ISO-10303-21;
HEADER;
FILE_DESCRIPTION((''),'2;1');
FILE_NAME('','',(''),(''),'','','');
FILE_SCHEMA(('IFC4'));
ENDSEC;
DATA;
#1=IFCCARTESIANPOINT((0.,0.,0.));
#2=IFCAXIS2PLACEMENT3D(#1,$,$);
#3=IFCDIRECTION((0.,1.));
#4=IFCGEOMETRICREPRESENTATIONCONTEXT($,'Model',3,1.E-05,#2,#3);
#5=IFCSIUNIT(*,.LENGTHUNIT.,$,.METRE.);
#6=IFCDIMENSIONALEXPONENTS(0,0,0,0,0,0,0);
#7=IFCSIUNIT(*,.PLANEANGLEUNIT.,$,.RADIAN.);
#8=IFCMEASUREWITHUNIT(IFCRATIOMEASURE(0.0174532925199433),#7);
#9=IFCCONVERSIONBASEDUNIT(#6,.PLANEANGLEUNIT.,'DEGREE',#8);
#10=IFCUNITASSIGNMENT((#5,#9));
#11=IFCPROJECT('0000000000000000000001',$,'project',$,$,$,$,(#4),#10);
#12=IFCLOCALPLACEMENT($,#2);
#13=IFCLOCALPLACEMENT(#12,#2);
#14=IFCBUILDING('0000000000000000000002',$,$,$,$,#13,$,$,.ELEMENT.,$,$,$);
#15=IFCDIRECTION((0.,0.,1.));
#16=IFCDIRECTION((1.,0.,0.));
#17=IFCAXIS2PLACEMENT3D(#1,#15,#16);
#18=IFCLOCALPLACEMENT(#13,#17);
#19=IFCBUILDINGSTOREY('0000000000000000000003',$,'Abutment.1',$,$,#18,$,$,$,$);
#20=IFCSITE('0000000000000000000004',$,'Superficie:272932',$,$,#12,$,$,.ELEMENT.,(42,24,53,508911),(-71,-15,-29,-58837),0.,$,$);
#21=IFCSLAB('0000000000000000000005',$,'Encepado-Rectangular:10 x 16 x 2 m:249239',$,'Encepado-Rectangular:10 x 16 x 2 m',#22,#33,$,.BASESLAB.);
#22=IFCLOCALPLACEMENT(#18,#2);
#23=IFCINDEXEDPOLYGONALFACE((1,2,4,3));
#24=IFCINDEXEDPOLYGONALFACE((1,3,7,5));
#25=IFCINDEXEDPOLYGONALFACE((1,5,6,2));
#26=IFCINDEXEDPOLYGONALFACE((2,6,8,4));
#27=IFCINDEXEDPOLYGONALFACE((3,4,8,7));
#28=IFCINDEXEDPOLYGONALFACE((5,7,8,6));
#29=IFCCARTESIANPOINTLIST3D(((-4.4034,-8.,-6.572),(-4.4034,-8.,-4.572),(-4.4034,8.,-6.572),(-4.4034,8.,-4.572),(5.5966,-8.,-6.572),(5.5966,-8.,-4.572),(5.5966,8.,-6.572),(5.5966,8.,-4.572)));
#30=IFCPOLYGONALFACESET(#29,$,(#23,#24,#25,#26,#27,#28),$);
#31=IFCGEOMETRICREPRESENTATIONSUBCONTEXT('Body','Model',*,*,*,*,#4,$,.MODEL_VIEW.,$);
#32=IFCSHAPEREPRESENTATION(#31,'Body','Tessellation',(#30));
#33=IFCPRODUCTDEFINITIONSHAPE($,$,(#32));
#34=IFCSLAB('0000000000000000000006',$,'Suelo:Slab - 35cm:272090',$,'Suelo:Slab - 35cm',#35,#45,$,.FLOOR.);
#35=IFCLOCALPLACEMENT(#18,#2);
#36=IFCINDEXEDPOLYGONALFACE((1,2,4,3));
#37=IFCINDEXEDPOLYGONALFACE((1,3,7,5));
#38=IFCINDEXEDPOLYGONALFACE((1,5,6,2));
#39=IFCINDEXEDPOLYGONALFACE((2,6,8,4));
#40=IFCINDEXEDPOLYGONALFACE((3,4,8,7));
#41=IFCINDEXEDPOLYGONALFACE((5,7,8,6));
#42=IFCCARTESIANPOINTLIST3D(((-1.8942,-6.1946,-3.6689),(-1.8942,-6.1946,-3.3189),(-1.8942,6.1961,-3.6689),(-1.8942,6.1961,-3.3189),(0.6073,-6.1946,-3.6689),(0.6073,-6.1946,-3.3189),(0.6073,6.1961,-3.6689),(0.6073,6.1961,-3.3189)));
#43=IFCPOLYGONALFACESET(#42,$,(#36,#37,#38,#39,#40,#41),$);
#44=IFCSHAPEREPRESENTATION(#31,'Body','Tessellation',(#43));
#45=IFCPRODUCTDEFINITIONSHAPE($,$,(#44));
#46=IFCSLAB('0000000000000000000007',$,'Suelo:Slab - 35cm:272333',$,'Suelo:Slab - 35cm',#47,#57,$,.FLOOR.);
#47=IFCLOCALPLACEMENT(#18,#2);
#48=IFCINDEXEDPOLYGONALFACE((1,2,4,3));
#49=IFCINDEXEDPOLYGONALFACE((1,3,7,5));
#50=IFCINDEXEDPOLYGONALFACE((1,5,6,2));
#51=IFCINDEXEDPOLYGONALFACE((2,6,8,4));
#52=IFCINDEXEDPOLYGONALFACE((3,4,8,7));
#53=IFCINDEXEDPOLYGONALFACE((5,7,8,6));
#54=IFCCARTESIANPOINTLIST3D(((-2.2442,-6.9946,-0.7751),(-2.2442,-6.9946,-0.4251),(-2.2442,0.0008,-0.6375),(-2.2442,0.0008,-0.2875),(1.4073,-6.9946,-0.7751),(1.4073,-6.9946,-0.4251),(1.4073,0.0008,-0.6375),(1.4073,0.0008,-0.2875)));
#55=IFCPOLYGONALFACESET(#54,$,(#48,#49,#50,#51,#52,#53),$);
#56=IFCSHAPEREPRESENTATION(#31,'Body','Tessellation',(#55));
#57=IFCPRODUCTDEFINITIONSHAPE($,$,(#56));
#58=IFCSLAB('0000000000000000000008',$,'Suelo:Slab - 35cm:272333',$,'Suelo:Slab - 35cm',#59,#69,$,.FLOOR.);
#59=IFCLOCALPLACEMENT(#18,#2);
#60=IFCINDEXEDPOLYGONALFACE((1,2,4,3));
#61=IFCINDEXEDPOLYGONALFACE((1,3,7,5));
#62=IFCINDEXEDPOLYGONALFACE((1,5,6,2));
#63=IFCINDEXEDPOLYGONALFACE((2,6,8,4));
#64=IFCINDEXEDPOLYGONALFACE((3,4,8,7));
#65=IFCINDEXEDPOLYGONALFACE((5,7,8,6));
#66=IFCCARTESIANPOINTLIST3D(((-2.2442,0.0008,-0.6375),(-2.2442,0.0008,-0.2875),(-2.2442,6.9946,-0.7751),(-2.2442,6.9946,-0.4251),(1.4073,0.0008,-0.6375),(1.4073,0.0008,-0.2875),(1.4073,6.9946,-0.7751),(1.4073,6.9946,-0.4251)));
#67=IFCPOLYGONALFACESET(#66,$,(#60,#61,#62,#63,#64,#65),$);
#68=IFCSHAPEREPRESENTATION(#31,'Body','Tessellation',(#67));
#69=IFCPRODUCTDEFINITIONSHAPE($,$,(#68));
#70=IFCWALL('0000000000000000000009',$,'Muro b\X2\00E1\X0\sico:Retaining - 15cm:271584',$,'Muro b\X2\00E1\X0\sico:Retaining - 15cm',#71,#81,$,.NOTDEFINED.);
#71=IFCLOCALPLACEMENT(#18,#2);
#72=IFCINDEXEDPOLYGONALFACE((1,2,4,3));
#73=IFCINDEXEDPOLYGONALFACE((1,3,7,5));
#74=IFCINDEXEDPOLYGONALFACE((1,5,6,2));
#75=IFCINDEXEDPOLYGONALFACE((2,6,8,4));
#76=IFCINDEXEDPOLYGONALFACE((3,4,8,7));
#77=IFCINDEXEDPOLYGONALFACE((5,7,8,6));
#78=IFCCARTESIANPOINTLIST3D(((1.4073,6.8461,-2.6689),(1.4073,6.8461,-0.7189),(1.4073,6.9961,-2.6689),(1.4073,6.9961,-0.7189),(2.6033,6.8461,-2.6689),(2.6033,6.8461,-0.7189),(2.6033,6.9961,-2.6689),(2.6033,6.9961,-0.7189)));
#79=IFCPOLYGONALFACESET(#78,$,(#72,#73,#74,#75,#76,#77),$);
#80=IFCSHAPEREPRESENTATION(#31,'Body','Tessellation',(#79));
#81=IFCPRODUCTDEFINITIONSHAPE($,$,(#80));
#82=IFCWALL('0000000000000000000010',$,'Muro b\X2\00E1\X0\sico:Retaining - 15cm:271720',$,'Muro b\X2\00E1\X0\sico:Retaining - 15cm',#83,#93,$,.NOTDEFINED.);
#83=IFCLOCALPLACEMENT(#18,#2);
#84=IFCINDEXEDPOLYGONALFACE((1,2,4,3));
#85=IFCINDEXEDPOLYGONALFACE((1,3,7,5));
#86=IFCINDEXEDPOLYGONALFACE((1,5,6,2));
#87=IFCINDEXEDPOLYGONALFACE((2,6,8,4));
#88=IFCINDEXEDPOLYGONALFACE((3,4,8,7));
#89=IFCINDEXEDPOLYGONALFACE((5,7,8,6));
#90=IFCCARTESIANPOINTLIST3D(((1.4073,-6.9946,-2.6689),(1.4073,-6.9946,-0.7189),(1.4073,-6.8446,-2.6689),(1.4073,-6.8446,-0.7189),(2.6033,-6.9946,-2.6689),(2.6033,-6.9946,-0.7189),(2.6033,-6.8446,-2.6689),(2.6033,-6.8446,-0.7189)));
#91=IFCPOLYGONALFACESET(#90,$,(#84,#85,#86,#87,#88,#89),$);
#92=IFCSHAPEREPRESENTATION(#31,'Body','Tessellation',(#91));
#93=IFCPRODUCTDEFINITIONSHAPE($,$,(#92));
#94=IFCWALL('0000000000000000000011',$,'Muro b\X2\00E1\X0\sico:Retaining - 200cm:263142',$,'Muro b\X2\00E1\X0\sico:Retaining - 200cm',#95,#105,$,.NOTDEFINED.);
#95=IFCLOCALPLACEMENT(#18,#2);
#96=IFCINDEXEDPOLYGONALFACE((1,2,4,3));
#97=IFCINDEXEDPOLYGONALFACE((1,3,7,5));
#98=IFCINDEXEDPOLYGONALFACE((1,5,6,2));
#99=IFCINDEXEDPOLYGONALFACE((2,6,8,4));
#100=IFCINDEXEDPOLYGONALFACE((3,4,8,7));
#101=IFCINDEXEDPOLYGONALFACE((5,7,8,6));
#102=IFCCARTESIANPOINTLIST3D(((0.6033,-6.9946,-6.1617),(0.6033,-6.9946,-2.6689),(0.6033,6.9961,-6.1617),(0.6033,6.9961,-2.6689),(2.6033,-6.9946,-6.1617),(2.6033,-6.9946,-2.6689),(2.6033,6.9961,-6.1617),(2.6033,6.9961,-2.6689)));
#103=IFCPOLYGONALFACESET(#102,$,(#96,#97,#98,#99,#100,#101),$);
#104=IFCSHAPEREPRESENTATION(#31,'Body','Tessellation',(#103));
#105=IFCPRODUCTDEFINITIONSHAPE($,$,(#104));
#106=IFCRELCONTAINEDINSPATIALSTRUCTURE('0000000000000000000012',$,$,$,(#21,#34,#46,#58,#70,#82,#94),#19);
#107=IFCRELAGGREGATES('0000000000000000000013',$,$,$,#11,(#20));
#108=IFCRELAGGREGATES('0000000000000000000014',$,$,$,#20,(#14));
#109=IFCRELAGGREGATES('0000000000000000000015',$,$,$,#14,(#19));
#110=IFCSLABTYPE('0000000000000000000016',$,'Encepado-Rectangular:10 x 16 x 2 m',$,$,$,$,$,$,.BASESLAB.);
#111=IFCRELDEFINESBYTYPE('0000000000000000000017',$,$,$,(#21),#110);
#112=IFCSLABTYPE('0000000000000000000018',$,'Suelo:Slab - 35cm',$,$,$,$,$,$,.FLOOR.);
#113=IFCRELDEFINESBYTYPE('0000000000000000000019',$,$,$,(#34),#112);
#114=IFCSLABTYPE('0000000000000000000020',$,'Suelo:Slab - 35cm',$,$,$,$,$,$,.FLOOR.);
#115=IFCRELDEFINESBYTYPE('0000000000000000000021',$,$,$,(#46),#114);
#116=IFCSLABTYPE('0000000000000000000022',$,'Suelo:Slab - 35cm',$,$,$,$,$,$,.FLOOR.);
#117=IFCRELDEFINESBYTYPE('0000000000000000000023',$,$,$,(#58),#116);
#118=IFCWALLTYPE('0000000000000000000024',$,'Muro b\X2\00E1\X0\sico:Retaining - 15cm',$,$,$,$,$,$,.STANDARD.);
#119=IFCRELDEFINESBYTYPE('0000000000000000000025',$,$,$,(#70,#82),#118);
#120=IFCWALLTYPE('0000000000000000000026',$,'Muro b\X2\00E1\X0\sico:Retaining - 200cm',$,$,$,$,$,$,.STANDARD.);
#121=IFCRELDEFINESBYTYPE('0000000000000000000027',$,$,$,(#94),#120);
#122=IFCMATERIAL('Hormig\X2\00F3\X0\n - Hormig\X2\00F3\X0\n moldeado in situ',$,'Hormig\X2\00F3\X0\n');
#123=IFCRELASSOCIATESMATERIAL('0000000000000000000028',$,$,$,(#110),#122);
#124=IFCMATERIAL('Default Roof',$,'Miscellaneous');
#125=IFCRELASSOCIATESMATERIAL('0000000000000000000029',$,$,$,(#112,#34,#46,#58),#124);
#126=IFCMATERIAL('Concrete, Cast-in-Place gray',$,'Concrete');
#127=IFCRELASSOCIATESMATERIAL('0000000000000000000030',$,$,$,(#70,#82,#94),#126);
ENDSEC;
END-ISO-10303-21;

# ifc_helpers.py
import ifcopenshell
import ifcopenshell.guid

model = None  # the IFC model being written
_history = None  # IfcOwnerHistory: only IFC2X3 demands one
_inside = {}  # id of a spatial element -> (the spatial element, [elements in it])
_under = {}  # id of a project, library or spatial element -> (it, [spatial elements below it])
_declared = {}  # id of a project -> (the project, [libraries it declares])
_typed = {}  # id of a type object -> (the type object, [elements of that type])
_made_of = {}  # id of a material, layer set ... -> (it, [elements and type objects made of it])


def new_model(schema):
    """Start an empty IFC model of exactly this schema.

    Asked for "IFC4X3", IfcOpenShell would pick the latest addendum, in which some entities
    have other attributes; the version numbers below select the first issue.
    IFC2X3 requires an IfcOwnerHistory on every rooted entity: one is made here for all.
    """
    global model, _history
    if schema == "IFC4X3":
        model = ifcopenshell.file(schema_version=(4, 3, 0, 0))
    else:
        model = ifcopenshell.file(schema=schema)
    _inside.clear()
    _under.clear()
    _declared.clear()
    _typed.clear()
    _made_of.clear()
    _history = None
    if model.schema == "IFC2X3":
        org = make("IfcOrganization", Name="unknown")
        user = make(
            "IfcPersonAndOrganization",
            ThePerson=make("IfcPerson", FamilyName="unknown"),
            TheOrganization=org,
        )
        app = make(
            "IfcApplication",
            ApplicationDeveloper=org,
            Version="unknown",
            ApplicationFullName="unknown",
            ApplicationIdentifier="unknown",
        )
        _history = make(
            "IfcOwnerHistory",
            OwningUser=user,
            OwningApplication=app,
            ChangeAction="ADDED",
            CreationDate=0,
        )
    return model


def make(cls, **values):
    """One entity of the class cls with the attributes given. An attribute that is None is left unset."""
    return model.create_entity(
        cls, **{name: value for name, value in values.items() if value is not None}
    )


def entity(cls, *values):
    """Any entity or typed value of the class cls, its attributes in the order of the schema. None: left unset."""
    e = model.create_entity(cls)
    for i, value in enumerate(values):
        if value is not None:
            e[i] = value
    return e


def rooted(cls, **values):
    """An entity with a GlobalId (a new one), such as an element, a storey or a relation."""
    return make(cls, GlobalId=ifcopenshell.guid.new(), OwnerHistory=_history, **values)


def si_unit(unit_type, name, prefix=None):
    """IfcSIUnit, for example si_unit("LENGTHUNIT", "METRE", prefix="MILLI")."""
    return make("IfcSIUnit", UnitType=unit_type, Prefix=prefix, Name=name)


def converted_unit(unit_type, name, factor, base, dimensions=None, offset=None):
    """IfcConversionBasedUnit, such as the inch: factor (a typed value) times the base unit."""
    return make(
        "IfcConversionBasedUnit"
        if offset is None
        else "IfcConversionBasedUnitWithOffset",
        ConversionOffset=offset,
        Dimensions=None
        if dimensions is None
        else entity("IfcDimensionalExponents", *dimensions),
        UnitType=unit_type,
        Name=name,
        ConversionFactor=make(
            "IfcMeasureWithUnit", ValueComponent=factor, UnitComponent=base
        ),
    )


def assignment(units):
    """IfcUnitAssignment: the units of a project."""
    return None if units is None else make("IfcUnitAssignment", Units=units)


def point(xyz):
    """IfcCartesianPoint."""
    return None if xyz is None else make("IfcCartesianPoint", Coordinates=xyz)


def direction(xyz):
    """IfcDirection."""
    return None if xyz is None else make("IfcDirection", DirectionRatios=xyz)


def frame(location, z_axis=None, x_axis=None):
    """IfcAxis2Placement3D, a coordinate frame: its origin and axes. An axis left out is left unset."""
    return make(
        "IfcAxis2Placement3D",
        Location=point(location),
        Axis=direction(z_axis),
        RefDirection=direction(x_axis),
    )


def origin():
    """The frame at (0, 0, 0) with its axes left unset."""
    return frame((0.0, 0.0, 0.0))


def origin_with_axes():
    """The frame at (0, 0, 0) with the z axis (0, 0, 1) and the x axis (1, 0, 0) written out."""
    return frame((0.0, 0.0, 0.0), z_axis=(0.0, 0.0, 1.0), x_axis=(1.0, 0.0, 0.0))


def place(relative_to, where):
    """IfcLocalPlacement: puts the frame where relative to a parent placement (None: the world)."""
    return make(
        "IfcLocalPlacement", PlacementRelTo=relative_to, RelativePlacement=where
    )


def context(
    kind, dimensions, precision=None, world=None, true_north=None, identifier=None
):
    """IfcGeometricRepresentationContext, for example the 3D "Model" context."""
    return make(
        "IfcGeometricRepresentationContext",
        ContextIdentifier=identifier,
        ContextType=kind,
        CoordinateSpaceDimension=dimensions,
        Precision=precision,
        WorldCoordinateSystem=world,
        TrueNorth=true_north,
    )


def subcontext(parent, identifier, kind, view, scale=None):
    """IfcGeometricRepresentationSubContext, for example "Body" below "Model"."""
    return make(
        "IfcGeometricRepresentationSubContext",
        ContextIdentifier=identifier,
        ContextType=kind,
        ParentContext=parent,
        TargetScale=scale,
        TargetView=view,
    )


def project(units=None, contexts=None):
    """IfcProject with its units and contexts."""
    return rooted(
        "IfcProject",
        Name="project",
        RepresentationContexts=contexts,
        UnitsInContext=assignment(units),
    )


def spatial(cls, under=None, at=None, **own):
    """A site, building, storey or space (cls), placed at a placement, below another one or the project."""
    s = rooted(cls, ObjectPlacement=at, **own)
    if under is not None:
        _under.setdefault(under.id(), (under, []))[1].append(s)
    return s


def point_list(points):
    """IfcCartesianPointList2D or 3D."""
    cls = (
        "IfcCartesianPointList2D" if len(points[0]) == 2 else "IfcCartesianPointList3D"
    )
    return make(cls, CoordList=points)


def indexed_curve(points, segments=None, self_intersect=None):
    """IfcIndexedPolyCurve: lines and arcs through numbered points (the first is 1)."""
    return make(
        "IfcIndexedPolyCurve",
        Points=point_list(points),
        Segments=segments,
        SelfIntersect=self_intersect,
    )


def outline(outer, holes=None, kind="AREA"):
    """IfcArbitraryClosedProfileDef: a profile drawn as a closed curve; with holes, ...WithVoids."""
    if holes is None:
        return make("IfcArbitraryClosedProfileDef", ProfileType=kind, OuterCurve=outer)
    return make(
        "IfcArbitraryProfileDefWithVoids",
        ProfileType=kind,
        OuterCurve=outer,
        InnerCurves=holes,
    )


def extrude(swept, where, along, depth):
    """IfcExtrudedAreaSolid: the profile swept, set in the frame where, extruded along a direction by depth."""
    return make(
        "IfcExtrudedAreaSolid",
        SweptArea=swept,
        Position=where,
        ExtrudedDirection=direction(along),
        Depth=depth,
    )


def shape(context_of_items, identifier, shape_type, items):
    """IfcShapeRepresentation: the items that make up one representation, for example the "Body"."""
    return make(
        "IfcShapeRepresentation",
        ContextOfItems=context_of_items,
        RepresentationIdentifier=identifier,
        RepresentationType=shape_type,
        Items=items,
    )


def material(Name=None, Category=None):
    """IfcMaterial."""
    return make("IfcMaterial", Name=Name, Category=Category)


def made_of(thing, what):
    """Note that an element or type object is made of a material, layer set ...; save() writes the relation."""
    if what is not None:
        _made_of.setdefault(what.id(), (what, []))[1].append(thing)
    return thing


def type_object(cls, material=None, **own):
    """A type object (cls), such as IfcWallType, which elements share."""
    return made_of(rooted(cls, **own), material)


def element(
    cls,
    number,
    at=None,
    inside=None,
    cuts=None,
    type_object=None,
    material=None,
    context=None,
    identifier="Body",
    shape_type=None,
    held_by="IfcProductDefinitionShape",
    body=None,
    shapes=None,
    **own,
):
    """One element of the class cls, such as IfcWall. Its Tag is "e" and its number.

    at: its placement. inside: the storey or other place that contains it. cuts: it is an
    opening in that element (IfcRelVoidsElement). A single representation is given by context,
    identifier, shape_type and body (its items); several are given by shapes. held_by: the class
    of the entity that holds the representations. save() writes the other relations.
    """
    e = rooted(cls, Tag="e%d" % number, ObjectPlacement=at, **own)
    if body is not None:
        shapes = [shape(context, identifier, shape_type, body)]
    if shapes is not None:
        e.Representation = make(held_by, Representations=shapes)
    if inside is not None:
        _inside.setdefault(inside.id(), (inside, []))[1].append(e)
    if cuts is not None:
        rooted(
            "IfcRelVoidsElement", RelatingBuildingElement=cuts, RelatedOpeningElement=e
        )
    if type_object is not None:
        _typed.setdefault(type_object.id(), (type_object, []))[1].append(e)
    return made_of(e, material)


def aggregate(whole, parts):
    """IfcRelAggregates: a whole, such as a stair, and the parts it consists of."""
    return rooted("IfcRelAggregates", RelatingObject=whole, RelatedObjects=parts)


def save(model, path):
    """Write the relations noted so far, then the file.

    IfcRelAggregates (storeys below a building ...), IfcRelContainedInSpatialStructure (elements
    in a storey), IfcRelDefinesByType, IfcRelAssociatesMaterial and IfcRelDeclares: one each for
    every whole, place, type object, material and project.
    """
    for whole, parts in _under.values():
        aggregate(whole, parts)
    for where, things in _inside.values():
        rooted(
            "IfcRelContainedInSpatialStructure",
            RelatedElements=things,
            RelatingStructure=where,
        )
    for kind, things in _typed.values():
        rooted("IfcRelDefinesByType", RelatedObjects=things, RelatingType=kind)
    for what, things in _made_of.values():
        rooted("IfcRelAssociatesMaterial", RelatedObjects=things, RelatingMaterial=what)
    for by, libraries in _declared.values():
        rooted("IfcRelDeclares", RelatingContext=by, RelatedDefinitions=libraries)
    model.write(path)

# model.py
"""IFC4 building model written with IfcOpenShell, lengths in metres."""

from ifc_helpers import new_model, entity, si_unit, converted_unit, direction, frame, origin, origin_with_axes, place, context, subcontext, project, spatial, indexed_curve, outline, extrude, material, type_object, element, save


model = new_model("IFC4")

# Units and contexts
model_context = context("Model", 3, precision=1e-05, world=origin(), true_north=direction((0.0, 1.0)))
body_context = subcontext(model_context, "Body", "Model", "MODEL_VIEW")
ifc_project = project(units=[si_unit("LENGTHUNIT", "METRE"), converted_unit("PLANEANGLEUNIT", "DEGREE", entity("IfcRatioMeasure", 0.0174532925199433), si_unit("PLANEANGLEUNIT", "RADIAN"), dimensions=[0, 0, 0, 0, 0, 0, 0])], contexts=[model_context])

# Site, building, storey
site_placement = place(None, origin())
site = spatial("IfcSite", under=ifc_project, at=site_placement, Name="Superficie:272932", CompositionType="ELEMENT", RefLatitude=(42, 24, 53, 508911), RefLongitude=(-71, -15, -29, -58837), RefElevation=0.0)
building_placement = place(site_placement, origin())
building = spatial("IfcBuilding", under=site, at=building_placement, CompositionType="ELEMENT")
storey_placement = place(building_placement, origin_with_axes())
storey = spatial("IfcBuildingStorey", under=building, at=storey_placement, Name="Abutment.1")

# Slabs
ifc_material_1 = material(Name="Hormigón - Hormigón moldeado in situ", Category="Hormigón")
slab_type_1 = type_object("IfcSlabType", Name="Encepado-Rectangular:10 x 16 x 2 m", PredefinedType="BASESLAB", material=ifc_material_1)
slab_1_placement = place(storey_placement, frame((0.0, 0.0, -6.1617), z_axis=(0.0, 0.0, 1.0), x_axis=(1.0, 0.0, 0.0)))
element("IfcSlab", 1, at=slab_1_placement, inside=storey, type_object=slab_type_1, Name="Encepado-Rectangular:10 x 16 x 2 m:249239", ObjectType="Encepado-Rectangular:10 x 16 x 2 m", PredefinedType="BASESLAB", context=body_context, shape_type="SweptSolid", body=[
    extrude(outline(indexed_curve([(-5.0, -8.0), (5.0, -8.0), (5.0, 8.0), (-5.0, 8.0), (-5.0, -8.0)], self_intersect=False)), frame((0.5966, 0.0, -0.4103), z_axis=(0.0, 0.0, 1.0), x_axis=(-1.0, 0.0, 0.0)), (0.0, 0.0, 1.0), 2.0),
])
ifc_material_2 = material(Name="Default Roof", Category="Miscellaneous")
slab_type_2 = type_object("IfcSlabType", Name="Suelo:Slab - 35cm", PredefinedType="FLOOR", material=ifc_material_2)
slab_2_placement = place(storey_placement, frame((0.0, 0.0, -2.6689), z_axis=(0.0, 0.0, 1.0), x_axis=(1.0, 0.0, 0.0)))
element("IfcSlab", 2, at=slab_2_placement, inside=storey, type_object=slab_type_2, material=ifc_material_2, Name="Suelo:Slab - 35cm:272090", ObjectType="Suelo:Slab - 35cm", PredefinedType="FLOOR", context=body_context, shape_type="SweptSolid", body=[
    extrude(outline(indexed_curve([(-6.1954, -1.2508), (6.1954, -1.2508), (6.1954, 1.2508), (-6.1954, 1.2508), (-6.1954, -1.2508)], self_intersect=False)), frame((-0.6435, 0.0008, -0.65), z_axis=(0.0, 0.0, -1.0), x_axis=(0.0, 1.0, 0.0)), (0.0, 0.0, 1.0), 0.35),
])
slab_type_3 = type_object("IfcSlabType", Name="Suelo:Slab - 35cm", PredefinedType="FLOOR")
slab_3_placement = place(storey_placement, frame((-2.2442, -6.9946, -0.7751), z_axis=(0.0, 0.0, 1.0), x_axis=(1.0, 0.0, 0.0)))
element("IfcSlab", 3, at=slab_3_placement, inside=storey, type_object=slab_type_3, material=ifc_material_2, Name="Suelo:Slab - 35cm:272333", ObjectType="Suelo:Slab - 35cm", PredefinedType="FLOOR", context=body_context, shape_type="SweptSolid", body=[
    extrude(outline(indexed_curve([(-1.8258, -3.4984), (1.8258, -3.4984), (1.8258, 3.4984), (-1.8258, 3.4984), (-1.8258, -3.4984)], self_intersect=False)), frame((1.8258, 3.4977, 0.4188), z_axis=(0.0, -0.019666, 0.999807), x_axis=(1.0, 0.0, 0.0)), (0.0, -0.019666, -0.999807), 0.35),
])
slab_type_4 = type_object("IfcSlabType", Name="Suelo:Slab - 35cm", PredefinedType="FLOOR")
slab_4_placement = place(storey_placement, frame((-2.2442, -6.9946, -0.7751), z_axis=(0.0, 0.0, 1.0), x_axis=(1.0, 0.0, 0.0)))
element("IfcSlab", 4, at=slab_4_placement, inside=storey, type_object=slab_type_4, material=ifc_material_2, Name="Suelo:Slab - 35cm:272333", ObjectType="Suelo:Slab - 35cm", PredefinedType="FLOOR", context=body_context, shape_type="SweptSolid", body=[
    extrude(outline(indexed_curve([(1.8258, 3.4976), (-1.8258, 3.4976), (-1.8258, -3.4976), (1.8258, -3.4976), (1.8258, 3.4976)], self_intersect=False)), frame((1.8258, 10.4923, 0.4188), z_axis=(0.0, 0.01967, 0.999807), x_axis=(1.0, 0.0, 0.0)), (0.0, 0.01967, -0.999807), 0.35),
])

# Walls
ifc_material_3 = material(Name="Concrete, Cast-in-Place gray", Category="Concrete")
wall_type_1 = type_object("IfcWallType", Name="Muro básico:Retaining - 15cm", PredefinedType="STANDARD")
wall_1_placement = place(storey_placement, frame((1.4073, 6.9211, -2.6689), z_axis=(0.0, 0.0, 1.0), x_axis=(1.0, 0.0, 0.0)))
element("IfcWall", 5, at=wall_1_placement, inside=storey, type_object=wall_type_1, material=ifc_material_3, Name="Muro básico:Retaining - 15cm:271584", ObjectType="Muro básico:Retaining - 15cm", PredefinedType="NOTDEFINED", context=body_context, shape_type="SweptSolid", body=[
    extrude(outline(indexed_curve([(1.196, 0.075), (0.0, 0.075), (0.0, -0.075), (1.196, -0.075), (1.196, 0.075)], self_intersect=False)), origin(), (0.0, 0.0, 1.0), 1.95),
])
wall_2_placement = place(storey_placement, frame((2.6033, -6.9196, -2.6689), z_axis=(0.0, 0.0, 1.0), x_axis=(-1.0, 0.0, 0.0)))
element("IfcWall", 6, at=wall_2_placement, inside=storey, type_object=wall_type_1, material=ifc_material_3, Name="Muro básico:Retaining - 15cm:271720", ObjectType="Muro básico:Retaining - 15cm", PredefinedType="NOTDEFINED", context=body_context, shape_type="SweptSolid", body=[
    extrude(outline(indexed_curve([(1.196, 0.075), (0.0, 0.075), (0.0, -0.075), (1.196, -0.075), (1.196, 0.075)], self_intersect=False)), origin(), (0.0, 0.0, 1.0), 1.95),
])
wall_type_2 = type_object("IfcWallType", Name="Muro básico:Retaining - 200cm", PredefinedType="STANDARD")
wall_3_placement = place(storey_placement, frame((1.6033, 6.9961, -6.1617), z_axis=(0.0, 0.0, 1.0), x_axis=(0.0, -1.0, 0.0)))
element("IfcWall", 7, at=wall_3_placement, inside=storey, type_object=wall_type_2, material=ifc_material_3, Name="Muro básico:Retaining - 200cm:263142", ObjectType="Muro básico:Retaining - 200cm", PredefinedType="NOTDEFINED", context=body_context, shape_type="SweptSolid", body=[
    extrude(outline(indexed_curve([(13.9908, 1.0), (0.0, 1.0), (0.0, -1.0), (13.9908, -1.0), (13.9908, 1.0)], self_intersect=False)), origin(), (0.0, 0.0, 1.0), 3.4928),
])

save(model, "model.ifc")
